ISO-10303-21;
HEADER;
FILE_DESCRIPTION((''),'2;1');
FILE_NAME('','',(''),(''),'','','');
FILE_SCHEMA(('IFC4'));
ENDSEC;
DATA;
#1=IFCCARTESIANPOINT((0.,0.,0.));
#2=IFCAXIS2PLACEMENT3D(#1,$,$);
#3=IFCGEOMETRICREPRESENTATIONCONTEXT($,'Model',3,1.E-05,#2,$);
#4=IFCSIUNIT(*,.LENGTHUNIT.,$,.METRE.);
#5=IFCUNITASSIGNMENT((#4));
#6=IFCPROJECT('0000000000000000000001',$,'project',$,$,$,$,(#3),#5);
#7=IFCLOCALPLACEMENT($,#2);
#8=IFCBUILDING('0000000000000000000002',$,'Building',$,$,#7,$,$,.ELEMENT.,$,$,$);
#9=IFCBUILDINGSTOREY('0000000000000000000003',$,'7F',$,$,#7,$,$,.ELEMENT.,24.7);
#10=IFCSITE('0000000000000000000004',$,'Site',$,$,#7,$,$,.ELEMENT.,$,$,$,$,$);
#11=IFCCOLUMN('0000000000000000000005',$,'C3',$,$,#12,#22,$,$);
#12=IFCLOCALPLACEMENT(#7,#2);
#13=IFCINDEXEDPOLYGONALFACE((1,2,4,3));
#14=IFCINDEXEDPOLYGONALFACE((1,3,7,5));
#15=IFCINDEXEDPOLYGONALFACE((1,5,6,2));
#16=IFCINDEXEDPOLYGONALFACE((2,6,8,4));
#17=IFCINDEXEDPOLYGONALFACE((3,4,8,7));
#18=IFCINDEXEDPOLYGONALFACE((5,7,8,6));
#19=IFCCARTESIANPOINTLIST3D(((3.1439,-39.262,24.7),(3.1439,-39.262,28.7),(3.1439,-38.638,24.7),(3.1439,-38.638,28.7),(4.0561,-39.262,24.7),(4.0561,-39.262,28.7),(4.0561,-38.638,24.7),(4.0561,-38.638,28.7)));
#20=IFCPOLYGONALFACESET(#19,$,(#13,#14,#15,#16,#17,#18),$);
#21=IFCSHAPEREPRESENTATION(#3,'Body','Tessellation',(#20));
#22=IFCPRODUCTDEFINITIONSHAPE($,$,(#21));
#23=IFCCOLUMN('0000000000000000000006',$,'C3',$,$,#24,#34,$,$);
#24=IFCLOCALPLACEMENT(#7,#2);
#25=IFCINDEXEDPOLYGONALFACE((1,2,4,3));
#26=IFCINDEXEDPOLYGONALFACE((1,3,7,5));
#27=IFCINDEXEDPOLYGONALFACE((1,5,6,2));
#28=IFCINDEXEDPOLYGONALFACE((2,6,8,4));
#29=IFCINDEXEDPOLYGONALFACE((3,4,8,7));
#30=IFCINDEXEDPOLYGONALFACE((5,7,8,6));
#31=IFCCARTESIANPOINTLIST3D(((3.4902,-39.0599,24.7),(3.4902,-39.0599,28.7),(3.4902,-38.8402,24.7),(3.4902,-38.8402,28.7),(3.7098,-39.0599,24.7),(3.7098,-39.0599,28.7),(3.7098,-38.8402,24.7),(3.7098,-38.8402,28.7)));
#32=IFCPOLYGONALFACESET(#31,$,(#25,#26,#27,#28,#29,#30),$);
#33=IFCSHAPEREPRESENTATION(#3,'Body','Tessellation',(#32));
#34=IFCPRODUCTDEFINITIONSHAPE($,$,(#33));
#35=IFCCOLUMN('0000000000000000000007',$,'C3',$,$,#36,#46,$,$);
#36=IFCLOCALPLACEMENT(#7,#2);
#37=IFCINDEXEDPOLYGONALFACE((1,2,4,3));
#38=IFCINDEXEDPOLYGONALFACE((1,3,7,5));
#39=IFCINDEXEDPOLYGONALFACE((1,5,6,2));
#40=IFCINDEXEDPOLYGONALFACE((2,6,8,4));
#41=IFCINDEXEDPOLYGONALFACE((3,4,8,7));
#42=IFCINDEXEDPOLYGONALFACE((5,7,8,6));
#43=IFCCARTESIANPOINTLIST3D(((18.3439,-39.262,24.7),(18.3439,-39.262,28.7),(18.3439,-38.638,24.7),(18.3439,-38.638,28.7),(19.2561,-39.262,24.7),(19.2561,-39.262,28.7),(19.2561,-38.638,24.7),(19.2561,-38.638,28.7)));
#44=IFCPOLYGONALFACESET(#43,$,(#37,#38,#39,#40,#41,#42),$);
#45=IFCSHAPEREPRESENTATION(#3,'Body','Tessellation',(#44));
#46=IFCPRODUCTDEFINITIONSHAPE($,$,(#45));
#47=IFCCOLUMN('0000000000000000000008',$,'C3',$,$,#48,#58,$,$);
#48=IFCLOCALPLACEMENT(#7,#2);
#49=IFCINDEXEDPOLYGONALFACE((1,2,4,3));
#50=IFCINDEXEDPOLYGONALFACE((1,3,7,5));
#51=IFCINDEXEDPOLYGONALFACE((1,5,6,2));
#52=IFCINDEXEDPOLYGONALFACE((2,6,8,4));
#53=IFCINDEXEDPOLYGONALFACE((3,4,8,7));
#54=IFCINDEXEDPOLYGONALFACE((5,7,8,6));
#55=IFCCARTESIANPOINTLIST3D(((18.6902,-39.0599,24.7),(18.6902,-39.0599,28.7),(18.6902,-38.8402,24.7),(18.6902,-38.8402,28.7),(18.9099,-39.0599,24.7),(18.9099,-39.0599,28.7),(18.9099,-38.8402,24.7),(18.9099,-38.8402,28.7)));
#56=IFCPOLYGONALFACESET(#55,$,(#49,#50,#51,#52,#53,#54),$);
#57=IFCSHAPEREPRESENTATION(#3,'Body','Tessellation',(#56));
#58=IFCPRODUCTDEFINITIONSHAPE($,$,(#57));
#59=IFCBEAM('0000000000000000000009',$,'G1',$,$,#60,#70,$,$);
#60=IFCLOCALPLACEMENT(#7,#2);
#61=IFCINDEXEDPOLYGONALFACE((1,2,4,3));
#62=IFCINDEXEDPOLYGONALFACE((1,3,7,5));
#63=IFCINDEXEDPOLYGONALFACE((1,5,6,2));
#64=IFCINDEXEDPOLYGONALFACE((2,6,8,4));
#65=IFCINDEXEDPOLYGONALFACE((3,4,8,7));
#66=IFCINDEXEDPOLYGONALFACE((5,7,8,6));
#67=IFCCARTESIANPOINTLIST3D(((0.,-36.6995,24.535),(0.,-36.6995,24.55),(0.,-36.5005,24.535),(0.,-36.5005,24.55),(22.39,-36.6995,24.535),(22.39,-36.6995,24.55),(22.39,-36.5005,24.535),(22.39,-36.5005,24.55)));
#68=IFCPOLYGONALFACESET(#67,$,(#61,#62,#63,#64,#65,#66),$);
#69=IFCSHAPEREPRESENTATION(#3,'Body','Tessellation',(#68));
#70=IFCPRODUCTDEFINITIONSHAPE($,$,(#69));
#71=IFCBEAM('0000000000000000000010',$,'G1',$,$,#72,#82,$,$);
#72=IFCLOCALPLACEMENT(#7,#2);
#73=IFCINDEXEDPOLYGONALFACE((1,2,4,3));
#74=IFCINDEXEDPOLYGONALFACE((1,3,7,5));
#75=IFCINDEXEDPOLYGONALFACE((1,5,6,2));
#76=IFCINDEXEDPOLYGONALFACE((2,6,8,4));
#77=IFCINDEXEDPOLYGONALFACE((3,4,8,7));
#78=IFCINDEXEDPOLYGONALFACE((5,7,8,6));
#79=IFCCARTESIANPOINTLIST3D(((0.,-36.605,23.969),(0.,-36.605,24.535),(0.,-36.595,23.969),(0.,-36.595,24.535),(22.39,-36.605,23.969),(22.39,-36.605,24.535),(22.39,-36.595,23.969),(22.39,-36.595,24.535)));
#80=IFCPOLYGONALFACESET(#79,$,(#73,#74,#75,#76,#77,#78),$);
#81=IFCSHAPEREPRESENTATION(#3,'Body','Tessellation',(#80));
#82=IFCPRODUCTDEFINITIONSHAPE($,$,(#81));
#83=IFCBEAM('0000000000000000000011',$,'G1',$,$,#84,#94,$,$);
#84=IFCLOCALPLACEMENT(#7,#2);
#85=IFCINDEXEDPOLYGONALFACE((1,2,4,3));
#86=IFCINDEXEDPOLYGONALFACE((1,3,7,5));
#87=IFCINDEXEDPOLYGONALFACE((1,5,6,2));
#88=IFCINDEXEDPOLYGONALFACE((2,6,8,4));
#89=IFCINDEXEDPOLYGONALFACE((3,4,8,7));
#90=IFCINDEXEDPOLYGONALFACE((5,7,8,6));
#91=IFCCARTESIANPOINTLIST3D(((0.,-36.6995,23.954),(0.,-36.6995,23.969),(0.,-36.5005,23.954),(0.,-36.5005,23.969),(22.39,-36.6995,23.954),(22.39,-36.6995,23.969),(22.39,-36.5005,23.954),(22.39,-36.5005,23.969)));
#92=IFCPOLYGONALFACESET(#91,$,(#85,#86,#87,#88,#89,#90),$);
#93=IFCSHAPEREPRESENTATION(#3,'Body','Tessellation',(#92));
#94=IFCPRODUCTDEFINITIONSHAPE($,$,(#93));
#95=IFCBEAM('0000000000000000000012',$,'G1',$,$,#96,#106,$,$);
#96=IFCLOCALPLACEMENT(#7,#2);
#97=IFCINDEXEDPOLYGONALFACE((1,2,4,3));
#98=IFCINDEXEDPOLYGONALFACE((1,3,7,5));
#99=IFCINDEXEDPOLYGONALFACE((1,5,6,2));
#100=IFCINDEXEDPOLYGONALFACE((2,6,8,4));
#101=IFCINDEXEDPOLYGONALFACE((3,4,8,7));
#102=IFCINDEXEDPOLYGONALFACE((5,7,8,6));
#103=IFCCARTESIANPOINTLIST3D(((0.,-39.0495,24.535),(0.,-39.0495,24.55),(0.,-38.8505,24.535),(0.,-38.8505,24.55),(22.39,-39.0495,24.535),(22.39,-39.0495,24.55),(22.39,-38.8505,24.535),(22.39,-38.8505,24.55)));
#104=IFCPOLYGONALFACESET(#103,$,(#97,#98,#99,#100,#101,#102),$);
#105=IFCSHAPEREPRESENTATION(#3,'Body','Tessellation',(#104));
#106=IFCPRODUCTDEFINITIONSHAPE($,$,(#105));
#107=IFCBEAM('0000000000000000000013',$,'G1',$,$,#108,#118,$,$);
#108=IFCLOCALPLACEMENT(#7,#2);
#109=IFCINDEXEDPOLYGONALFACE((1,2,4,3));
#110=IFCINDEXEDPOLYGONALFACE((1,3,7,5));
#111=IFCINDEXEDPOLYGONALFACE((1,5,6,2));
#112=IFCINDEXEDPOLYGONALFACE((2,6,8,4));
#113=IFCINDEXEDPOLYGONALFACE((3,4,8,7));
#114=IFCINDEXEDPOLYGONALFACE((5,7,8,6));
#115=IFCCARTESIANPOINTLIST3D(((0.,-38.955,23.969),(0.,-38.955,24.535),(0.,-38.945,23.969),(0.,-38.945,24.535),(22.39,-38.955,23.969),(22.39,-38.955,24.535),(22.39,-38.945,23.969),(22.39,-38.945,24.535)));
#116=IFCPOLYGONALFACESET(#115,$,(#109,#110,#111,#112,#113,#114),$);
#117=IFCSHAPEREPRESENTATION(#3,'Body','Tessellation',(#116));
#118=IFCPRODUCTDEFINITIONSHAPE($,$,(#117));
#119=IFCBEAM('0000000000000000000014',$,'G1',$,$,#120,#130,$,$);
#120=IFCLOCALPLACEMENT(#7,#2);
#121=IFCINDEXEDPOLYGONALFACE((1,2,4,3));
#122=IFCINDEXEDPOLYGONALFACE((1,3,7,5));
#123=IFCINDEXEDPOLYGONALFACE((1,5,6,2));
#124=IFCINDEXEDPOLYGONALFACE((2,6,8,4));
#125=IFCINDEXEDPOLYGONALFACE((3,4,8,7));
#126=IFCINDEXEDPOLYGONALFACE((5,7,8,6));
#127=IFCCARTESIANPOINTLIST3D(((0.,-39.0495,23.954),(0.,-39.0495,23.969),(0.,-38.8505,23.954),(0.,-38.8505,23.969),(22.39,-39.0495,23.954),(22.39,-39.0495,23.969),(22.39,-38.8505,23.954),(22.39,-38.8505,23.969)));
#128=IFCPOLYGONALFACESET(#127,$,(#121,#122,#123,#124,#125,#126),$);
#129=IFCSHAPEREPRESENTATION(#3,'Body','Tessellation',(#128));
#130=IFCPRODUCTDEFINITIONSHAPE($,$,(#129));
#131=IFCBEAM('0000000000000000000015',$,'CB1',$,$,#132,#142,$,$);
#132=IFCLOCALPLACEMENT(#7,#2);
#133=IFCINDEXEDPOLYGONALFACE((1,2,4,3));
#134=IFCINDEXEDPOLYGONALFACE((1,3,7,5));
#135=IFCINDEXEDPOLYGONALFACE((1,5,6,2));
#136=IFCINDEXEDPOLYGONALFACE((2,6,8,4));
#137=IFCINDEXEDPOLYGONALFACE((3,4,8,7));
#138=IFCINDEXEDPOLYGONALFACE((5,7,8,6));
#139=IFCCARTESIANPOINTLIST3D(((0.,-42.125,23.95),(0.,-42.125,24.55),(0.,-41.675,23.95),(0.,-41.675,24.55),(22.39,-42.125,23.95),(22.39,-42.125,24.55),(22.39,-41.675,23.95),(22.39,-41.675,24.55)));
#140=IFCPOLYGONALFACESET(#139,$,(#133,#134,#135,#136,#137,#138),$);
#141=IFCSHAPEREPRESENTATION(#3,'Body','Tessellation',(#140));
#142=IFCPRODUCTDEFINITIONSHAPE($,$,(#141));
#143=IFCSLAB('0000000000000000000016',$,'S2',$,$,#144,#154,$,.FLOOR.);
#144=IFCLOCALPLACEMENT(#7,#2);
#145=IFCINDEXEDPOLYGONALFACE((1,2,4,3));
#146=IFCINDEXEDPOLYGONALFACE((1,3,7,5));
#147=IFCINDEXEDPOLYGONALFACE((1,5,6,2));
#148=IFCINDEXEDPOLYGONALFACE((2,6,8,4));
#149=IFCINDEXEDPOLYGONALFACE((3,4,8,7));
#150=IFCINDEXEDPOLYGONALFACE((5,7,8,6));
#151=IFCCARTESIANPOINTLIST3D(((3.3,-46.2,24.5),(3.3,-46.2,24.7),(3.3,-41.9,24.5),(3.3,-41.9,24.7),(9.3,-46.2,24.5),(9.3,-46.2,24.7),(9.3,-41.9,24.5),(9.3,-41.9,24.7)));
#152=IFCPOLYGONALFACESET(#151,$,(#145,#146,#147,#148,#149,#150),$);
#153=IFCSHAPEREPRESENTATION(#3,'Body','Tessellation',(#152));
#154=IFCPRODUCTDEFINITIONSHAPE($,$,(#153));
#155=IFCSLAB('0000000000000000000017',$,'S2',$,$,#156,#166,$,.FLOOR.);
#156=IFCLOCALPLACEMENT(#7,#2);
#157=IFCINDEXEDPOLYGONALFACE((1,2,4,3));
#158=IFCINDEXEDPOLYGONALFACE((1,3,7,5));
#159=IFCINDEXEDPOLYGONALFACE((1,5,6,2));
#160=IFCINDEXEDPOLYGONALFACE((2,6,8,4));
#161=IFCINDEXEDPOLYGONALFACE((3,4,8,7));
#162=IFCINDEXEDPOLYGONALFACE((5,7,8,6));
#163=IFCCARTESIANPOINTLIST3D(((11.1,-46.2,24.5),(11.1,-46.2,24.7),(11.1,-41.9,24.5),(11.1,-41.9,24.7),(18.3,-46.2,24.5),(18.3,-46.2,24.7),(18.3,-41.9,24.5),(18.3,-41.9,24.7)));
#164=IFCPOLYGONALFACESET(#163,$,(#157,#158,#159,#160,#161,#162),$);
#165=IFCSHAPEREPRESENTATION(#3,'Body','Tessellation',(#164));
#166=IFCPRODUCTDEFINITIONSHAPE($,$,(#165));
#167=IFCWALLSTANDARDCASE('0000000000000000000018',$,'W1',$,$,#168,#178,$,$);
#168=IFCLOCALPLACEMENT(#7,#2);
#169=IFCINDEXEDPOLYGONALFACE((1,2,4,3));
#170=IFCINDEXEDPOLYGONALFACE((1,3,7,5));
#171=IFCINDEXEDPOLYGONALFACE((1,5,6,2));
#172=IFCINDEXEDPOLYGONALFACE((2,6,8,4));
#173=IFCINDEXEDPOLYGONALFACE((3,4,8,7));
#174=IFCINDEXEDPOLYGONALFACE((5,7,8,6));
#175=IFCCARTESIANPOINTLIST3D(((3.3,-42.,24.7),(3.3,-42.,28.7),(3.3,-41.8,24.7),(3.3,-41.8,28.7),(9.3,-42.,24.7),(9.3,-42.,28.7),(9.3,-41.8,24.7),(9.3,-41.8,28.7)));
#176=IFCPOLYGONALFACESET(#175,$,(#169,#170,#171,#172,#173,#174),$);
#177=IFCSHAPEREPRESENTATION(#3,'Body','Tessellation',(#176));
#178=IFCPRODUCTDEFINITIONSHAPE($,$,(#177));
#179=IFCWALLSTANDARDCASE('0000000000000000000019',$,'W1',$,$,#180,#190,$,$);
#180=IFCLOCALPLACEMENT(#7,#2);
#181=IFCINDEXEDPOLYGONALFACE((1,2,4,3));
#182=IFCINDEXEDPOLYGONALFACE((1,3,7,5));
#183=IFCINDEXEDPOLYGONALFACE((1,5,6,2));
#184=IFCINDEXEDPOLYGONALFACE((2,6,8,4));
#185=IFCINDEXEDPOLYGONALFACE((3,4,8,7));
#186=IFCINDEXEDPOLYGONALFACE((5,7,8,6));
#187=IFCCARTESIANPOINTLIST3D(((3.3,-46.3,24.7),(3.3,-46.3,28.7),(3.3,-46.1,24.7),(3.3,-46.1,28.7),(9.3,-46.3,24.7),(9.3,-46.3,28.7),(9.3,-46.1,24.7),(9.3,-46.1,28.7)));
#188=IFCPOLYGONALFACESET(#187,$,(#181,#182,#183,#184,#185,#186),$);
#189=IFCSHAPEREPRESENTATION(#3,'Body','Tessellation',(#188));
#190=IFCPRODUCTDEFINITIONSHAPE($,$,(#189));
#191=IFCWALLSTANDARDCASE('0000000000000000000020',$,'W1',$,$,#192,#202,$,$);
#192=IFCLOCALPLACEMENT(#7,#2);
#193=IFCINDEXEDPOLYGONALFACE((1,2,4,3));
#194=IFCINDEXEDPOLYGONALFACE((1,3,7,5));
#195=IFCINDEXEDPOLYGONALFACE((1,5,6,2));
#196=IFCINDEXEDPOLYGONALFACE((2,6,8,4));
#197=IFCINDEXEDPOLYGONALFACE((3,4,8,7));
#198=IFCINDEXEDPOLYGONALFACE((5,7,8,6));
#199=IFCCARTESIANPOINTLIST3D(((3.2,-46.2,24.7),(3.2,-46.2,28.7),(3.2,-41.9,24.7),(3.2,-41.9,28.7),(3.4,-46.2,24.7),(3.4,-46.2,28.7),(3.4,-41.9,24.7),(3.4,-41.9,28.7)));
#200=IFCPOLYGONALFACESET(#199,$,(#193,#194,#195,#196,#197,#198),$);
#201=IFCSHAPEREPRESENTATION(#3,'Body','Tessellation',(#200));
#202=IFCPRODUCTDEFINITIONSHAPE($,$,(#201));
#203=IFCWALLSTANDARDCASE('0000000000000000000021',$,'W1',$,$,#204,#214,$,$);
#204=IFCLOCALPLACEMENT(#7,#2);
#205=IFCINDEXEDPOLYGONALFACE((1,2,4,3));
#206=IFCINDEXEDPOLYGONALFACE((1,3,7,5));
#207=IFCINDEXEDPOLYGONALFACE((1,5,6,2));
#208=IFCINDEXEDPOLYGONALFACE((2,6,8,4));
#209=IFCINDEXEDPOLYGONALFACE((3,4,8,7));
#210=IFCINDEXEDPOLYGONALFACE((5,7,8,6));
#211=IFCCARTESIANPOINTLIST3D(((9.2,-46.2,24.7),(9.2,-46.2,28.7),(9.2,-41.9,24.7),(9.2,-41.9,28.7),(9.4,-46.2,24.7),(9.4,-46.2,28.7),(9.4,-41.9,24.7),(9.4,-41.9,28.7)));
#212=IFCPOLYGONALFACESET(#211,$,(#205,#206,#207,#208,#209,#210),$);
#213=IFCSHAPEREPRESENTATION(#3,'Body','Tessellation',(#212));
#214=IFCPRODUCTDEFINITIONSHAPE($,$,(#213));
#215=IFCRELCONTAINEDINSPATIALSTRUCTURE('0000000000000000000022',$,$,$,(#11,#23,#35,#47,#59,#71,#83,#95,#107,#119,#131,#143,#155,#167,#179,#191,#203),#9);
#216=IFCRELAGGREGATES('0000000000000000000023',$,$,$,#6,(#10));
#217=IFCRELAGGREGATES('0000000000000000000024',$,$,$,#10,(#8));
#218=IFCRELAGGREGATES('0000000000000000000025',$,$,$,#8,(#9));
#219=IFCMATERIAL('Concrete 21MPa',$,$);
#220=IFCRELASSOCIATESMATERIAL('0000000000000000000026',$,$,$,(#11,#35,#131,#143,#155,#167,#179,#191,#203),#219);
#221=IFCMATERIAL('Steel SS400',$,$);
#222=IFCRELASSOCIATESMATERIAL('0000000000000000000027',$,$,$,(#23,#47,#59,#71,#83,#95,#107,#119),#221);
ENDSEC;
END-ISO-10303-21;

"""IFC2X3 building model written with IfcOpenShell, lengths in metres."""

from ifc_helpers import new_model, si_unit, frame, origin, origin_2d, place, context, project, spatial, rectangle, extrude, material, element, save


model = new_model("IFC2X3")

# Units and contexts
model_context = context("Model", 3, precision=1e-05, world=origin())
ifc_project = project(units=[si_unit("LENGTHUNIT", "METRE")], contexts=[model_context])

# Site, building, storey
placement = place(None, origin())
site = spatial("IfcSite", under=ifc_project, at=placement, Name="Site", CompositionType="ELEMENT")
building = spatial("IfcBuilding", under=site, at=placement, Name="Building", CompositionType="ELEMENT")
storey = spatial("IfcBuildingStorey", under=building, at=placement, Name="7F", CompositionType="ELEMENT", Elevation=24.7)

# Columns
ifc_material_1 = material(Name="Concrete 21MPa")
column_1_placement = place(None, frame((3.6, -38.95, 24.7)))
element("IfcColumn", 1, at=column_1_placement, inside=storey, material=ifc_material_1, Name="C3", context=model_context, shape_type="SweptSolid", body=[
    extrude(rectangle(XDim=0.9121, YDim=0.6241, at=origin_2d()), origin(), (0.0, 0.0, 1.0), 4.0),
])
ifc_material_2 = material(Name="Steel SS400")
column_2_placement = place(None, frame((3.6, -38.95, 24.7)))
element("IfcColumn", 2, at=column_2_placement, inside=storey, material=ifc_material_2, Name="C3", context=model_context, shape_type="SweptSolid", body=[
    extrude(rectangle(XDim=0.2197, YDim=0.2197, at=origin_2d()), origin(), (0.0, 0.0, 1.0), 4.0),
])
column_3_placement = place(None, frame((18.8, -38.95, 24.7)))
element("IfcColumn", 3, at=column_3_placement, inside=storey, material=ifc_material_1, Name="C3", context=model_context, shape_type="SweptSolid", body=[
    extrude(rectangle(XDim=0.9121, YDim=0.6241, at=origin_2d()), origin(), (0.0, 0.0, 1.0), 4.0),
])
column_4_placement = place(None, frame((18.8, -38.95, 24.7)))
element("IfcColumn", 4, at=column_4_placement, inside=storey, material=ifc_material_2, Name="C3", context=model_context, shape_type="SweptSolid", body=[
    extrude(rectangle(XDim=0.2197, YDim=0.2197, at=origin_2d()), origin(), (0.0, 0.0, 1.0), 4.0),
])

# Beams
beam_1_placement = place(None, frame((11.195, -36.6, 24.535)))
element("IfcBeam", 5, at=beam_1_placement, inside=storey, material=ifc_material_2, Name="G1", context=model_context, shape_type="SweptSolid", body=[
    extrude(rectangle(XDim=22.39, YDim=0.199, at=origin_2d()), origin(), (0.0, 0.0, 1.0), 0.015),
])
beam_2_placement = place(None, frame((11.195, -36.6, 23.969)))
element("IfcBeam", 6, at=beam_2_placement, inside=storey, material=ifc_material_2, Name="G1", context=model_context, shape_type="SweptSolid", body=[
    extrude(rectangle(XDim=22.39, YDim=0.01, at=origin_2d()), origin(), (0.0, 0.0, 1.0), 0.566),
])
for number, where, name in (
    (7, (11.195, -36.6, 23.954), "G1"),
    (8, (11.195, -38.95, 24.535), "G1"),
):
    element("IfcBeam", number, at=place(None, frame(where)), inside=storey, material=ifc_material_2, Name=name, context=model_context, shape_type="SweptSolid", body=[
        extrude(rectangle(XDim=22.39, YDim=0.199, at=origin_2d()), origin(), (0.0, 0.0, 1.0), 0.015),
    ])
beam_3_placement = place(None, frame((11.195, -38.95, 23.969)))
element("IfcBeam", 9, at=beam_3_placement, inside=storey, material=ifc_material_2, Name="G1", context=model_context, shape_type="SweptSolid", body=[
    extrude(rectangle(XDim=22.39, YDim=0.01, at=origin_2d()), origin(), (0.0, 0.0, 1.0), 0.566),
])
beam_4_placement = place(None, frame((11.195, -38.95, 23.954)))
element("IfcBeam", 10, at=beam_4_placement, inside=storey, material=ifc_material_2, Name="G1", context=model_context, shape_type="SweptSolid", body=[
    extrude(rectangle(XDim=22.39, YDim=0.199, at=origin_2d()), origin(), (0.0, 0.0, 1.0), 0.015),
])
beam_5_placement = place(None, frame((11.195, -41.9, 23.95)))
element("IfcBeam", 11, at=beam_5_placement, inside=storey, material=ifc_material_1, Name="CB1", context=model_context, shape_type="SweptSolid", body=[
    extrude(rectangle(XDim=22.39, YDim=0.45, at=origin_2d()), origin(), (0.0, 0.0, 1.0), 0.6),
])

# Slabs
slab_1_placement = place(None, frame((6.3, -44.05, 24.5)))
element("IfcSlab", 12, at=slab_1_placement, inside=storey, material=ifc_material_1, Name="S2", PredefinedType="FLOOR", context=model_context, shape_type="SweptSolid", body=[
    extrude(rectangle(XDim=6.0, YDim=4.3, at=origin_2d()), origin(), (0.0, 0.0, 1.0), 0.2),
])
slab_2_placement = place(None, frame((14.7, -44.05, 24.5)))
element("IfcSlab", 13, at=slab_2_placement, inside=storey, material=ifc_material_1, Name="S2", PredefinedType="FLOOR", context=model_context, shape_type="SweptSolid", body=[
    extrude(rectangle(XDim=7.2, YDim=4.3, at=origin_2d()), origin(), (0.0, 0.0, 1.0), 0.2),
])

# Walls
for number, where, name in (
    (14, (6.3, -41.9, 24.7), "W1"),
    (15, (6.3, -46.2, 24.7), "W1"),
):
    element("IfcWallStandardCase", number, at=place(None, frame(where)), inside=storey, material=ifc_material_1, Name=name, context=model_context, shape_type="SweptSolid", body=[
        extrude(rectangle(XDim=6.0, YDim=0.2, at=origin_2d()), origin(), (0.0, 0.0, 1.0), 4.0),
    ])
for number, where, name in (
    (16, (3.3, -44.05, 24.7), "W1"),
    (17, (9.3, -44.05, 24.7), "W1"),
):
    element("IfcWallStandardCase", number, at=place(None, frame(where)), inside=storey, material=ifc_material_1, Name=name, context=model_context, shape_type="SweptSolid", body=[
        extrude(rectangle(XDim=0.2, YDim=4.3, at=origin_2d()), origin(), (0.0, 0.0, 1.0), 4.0),
    ])

save(model, "model.ifc")
